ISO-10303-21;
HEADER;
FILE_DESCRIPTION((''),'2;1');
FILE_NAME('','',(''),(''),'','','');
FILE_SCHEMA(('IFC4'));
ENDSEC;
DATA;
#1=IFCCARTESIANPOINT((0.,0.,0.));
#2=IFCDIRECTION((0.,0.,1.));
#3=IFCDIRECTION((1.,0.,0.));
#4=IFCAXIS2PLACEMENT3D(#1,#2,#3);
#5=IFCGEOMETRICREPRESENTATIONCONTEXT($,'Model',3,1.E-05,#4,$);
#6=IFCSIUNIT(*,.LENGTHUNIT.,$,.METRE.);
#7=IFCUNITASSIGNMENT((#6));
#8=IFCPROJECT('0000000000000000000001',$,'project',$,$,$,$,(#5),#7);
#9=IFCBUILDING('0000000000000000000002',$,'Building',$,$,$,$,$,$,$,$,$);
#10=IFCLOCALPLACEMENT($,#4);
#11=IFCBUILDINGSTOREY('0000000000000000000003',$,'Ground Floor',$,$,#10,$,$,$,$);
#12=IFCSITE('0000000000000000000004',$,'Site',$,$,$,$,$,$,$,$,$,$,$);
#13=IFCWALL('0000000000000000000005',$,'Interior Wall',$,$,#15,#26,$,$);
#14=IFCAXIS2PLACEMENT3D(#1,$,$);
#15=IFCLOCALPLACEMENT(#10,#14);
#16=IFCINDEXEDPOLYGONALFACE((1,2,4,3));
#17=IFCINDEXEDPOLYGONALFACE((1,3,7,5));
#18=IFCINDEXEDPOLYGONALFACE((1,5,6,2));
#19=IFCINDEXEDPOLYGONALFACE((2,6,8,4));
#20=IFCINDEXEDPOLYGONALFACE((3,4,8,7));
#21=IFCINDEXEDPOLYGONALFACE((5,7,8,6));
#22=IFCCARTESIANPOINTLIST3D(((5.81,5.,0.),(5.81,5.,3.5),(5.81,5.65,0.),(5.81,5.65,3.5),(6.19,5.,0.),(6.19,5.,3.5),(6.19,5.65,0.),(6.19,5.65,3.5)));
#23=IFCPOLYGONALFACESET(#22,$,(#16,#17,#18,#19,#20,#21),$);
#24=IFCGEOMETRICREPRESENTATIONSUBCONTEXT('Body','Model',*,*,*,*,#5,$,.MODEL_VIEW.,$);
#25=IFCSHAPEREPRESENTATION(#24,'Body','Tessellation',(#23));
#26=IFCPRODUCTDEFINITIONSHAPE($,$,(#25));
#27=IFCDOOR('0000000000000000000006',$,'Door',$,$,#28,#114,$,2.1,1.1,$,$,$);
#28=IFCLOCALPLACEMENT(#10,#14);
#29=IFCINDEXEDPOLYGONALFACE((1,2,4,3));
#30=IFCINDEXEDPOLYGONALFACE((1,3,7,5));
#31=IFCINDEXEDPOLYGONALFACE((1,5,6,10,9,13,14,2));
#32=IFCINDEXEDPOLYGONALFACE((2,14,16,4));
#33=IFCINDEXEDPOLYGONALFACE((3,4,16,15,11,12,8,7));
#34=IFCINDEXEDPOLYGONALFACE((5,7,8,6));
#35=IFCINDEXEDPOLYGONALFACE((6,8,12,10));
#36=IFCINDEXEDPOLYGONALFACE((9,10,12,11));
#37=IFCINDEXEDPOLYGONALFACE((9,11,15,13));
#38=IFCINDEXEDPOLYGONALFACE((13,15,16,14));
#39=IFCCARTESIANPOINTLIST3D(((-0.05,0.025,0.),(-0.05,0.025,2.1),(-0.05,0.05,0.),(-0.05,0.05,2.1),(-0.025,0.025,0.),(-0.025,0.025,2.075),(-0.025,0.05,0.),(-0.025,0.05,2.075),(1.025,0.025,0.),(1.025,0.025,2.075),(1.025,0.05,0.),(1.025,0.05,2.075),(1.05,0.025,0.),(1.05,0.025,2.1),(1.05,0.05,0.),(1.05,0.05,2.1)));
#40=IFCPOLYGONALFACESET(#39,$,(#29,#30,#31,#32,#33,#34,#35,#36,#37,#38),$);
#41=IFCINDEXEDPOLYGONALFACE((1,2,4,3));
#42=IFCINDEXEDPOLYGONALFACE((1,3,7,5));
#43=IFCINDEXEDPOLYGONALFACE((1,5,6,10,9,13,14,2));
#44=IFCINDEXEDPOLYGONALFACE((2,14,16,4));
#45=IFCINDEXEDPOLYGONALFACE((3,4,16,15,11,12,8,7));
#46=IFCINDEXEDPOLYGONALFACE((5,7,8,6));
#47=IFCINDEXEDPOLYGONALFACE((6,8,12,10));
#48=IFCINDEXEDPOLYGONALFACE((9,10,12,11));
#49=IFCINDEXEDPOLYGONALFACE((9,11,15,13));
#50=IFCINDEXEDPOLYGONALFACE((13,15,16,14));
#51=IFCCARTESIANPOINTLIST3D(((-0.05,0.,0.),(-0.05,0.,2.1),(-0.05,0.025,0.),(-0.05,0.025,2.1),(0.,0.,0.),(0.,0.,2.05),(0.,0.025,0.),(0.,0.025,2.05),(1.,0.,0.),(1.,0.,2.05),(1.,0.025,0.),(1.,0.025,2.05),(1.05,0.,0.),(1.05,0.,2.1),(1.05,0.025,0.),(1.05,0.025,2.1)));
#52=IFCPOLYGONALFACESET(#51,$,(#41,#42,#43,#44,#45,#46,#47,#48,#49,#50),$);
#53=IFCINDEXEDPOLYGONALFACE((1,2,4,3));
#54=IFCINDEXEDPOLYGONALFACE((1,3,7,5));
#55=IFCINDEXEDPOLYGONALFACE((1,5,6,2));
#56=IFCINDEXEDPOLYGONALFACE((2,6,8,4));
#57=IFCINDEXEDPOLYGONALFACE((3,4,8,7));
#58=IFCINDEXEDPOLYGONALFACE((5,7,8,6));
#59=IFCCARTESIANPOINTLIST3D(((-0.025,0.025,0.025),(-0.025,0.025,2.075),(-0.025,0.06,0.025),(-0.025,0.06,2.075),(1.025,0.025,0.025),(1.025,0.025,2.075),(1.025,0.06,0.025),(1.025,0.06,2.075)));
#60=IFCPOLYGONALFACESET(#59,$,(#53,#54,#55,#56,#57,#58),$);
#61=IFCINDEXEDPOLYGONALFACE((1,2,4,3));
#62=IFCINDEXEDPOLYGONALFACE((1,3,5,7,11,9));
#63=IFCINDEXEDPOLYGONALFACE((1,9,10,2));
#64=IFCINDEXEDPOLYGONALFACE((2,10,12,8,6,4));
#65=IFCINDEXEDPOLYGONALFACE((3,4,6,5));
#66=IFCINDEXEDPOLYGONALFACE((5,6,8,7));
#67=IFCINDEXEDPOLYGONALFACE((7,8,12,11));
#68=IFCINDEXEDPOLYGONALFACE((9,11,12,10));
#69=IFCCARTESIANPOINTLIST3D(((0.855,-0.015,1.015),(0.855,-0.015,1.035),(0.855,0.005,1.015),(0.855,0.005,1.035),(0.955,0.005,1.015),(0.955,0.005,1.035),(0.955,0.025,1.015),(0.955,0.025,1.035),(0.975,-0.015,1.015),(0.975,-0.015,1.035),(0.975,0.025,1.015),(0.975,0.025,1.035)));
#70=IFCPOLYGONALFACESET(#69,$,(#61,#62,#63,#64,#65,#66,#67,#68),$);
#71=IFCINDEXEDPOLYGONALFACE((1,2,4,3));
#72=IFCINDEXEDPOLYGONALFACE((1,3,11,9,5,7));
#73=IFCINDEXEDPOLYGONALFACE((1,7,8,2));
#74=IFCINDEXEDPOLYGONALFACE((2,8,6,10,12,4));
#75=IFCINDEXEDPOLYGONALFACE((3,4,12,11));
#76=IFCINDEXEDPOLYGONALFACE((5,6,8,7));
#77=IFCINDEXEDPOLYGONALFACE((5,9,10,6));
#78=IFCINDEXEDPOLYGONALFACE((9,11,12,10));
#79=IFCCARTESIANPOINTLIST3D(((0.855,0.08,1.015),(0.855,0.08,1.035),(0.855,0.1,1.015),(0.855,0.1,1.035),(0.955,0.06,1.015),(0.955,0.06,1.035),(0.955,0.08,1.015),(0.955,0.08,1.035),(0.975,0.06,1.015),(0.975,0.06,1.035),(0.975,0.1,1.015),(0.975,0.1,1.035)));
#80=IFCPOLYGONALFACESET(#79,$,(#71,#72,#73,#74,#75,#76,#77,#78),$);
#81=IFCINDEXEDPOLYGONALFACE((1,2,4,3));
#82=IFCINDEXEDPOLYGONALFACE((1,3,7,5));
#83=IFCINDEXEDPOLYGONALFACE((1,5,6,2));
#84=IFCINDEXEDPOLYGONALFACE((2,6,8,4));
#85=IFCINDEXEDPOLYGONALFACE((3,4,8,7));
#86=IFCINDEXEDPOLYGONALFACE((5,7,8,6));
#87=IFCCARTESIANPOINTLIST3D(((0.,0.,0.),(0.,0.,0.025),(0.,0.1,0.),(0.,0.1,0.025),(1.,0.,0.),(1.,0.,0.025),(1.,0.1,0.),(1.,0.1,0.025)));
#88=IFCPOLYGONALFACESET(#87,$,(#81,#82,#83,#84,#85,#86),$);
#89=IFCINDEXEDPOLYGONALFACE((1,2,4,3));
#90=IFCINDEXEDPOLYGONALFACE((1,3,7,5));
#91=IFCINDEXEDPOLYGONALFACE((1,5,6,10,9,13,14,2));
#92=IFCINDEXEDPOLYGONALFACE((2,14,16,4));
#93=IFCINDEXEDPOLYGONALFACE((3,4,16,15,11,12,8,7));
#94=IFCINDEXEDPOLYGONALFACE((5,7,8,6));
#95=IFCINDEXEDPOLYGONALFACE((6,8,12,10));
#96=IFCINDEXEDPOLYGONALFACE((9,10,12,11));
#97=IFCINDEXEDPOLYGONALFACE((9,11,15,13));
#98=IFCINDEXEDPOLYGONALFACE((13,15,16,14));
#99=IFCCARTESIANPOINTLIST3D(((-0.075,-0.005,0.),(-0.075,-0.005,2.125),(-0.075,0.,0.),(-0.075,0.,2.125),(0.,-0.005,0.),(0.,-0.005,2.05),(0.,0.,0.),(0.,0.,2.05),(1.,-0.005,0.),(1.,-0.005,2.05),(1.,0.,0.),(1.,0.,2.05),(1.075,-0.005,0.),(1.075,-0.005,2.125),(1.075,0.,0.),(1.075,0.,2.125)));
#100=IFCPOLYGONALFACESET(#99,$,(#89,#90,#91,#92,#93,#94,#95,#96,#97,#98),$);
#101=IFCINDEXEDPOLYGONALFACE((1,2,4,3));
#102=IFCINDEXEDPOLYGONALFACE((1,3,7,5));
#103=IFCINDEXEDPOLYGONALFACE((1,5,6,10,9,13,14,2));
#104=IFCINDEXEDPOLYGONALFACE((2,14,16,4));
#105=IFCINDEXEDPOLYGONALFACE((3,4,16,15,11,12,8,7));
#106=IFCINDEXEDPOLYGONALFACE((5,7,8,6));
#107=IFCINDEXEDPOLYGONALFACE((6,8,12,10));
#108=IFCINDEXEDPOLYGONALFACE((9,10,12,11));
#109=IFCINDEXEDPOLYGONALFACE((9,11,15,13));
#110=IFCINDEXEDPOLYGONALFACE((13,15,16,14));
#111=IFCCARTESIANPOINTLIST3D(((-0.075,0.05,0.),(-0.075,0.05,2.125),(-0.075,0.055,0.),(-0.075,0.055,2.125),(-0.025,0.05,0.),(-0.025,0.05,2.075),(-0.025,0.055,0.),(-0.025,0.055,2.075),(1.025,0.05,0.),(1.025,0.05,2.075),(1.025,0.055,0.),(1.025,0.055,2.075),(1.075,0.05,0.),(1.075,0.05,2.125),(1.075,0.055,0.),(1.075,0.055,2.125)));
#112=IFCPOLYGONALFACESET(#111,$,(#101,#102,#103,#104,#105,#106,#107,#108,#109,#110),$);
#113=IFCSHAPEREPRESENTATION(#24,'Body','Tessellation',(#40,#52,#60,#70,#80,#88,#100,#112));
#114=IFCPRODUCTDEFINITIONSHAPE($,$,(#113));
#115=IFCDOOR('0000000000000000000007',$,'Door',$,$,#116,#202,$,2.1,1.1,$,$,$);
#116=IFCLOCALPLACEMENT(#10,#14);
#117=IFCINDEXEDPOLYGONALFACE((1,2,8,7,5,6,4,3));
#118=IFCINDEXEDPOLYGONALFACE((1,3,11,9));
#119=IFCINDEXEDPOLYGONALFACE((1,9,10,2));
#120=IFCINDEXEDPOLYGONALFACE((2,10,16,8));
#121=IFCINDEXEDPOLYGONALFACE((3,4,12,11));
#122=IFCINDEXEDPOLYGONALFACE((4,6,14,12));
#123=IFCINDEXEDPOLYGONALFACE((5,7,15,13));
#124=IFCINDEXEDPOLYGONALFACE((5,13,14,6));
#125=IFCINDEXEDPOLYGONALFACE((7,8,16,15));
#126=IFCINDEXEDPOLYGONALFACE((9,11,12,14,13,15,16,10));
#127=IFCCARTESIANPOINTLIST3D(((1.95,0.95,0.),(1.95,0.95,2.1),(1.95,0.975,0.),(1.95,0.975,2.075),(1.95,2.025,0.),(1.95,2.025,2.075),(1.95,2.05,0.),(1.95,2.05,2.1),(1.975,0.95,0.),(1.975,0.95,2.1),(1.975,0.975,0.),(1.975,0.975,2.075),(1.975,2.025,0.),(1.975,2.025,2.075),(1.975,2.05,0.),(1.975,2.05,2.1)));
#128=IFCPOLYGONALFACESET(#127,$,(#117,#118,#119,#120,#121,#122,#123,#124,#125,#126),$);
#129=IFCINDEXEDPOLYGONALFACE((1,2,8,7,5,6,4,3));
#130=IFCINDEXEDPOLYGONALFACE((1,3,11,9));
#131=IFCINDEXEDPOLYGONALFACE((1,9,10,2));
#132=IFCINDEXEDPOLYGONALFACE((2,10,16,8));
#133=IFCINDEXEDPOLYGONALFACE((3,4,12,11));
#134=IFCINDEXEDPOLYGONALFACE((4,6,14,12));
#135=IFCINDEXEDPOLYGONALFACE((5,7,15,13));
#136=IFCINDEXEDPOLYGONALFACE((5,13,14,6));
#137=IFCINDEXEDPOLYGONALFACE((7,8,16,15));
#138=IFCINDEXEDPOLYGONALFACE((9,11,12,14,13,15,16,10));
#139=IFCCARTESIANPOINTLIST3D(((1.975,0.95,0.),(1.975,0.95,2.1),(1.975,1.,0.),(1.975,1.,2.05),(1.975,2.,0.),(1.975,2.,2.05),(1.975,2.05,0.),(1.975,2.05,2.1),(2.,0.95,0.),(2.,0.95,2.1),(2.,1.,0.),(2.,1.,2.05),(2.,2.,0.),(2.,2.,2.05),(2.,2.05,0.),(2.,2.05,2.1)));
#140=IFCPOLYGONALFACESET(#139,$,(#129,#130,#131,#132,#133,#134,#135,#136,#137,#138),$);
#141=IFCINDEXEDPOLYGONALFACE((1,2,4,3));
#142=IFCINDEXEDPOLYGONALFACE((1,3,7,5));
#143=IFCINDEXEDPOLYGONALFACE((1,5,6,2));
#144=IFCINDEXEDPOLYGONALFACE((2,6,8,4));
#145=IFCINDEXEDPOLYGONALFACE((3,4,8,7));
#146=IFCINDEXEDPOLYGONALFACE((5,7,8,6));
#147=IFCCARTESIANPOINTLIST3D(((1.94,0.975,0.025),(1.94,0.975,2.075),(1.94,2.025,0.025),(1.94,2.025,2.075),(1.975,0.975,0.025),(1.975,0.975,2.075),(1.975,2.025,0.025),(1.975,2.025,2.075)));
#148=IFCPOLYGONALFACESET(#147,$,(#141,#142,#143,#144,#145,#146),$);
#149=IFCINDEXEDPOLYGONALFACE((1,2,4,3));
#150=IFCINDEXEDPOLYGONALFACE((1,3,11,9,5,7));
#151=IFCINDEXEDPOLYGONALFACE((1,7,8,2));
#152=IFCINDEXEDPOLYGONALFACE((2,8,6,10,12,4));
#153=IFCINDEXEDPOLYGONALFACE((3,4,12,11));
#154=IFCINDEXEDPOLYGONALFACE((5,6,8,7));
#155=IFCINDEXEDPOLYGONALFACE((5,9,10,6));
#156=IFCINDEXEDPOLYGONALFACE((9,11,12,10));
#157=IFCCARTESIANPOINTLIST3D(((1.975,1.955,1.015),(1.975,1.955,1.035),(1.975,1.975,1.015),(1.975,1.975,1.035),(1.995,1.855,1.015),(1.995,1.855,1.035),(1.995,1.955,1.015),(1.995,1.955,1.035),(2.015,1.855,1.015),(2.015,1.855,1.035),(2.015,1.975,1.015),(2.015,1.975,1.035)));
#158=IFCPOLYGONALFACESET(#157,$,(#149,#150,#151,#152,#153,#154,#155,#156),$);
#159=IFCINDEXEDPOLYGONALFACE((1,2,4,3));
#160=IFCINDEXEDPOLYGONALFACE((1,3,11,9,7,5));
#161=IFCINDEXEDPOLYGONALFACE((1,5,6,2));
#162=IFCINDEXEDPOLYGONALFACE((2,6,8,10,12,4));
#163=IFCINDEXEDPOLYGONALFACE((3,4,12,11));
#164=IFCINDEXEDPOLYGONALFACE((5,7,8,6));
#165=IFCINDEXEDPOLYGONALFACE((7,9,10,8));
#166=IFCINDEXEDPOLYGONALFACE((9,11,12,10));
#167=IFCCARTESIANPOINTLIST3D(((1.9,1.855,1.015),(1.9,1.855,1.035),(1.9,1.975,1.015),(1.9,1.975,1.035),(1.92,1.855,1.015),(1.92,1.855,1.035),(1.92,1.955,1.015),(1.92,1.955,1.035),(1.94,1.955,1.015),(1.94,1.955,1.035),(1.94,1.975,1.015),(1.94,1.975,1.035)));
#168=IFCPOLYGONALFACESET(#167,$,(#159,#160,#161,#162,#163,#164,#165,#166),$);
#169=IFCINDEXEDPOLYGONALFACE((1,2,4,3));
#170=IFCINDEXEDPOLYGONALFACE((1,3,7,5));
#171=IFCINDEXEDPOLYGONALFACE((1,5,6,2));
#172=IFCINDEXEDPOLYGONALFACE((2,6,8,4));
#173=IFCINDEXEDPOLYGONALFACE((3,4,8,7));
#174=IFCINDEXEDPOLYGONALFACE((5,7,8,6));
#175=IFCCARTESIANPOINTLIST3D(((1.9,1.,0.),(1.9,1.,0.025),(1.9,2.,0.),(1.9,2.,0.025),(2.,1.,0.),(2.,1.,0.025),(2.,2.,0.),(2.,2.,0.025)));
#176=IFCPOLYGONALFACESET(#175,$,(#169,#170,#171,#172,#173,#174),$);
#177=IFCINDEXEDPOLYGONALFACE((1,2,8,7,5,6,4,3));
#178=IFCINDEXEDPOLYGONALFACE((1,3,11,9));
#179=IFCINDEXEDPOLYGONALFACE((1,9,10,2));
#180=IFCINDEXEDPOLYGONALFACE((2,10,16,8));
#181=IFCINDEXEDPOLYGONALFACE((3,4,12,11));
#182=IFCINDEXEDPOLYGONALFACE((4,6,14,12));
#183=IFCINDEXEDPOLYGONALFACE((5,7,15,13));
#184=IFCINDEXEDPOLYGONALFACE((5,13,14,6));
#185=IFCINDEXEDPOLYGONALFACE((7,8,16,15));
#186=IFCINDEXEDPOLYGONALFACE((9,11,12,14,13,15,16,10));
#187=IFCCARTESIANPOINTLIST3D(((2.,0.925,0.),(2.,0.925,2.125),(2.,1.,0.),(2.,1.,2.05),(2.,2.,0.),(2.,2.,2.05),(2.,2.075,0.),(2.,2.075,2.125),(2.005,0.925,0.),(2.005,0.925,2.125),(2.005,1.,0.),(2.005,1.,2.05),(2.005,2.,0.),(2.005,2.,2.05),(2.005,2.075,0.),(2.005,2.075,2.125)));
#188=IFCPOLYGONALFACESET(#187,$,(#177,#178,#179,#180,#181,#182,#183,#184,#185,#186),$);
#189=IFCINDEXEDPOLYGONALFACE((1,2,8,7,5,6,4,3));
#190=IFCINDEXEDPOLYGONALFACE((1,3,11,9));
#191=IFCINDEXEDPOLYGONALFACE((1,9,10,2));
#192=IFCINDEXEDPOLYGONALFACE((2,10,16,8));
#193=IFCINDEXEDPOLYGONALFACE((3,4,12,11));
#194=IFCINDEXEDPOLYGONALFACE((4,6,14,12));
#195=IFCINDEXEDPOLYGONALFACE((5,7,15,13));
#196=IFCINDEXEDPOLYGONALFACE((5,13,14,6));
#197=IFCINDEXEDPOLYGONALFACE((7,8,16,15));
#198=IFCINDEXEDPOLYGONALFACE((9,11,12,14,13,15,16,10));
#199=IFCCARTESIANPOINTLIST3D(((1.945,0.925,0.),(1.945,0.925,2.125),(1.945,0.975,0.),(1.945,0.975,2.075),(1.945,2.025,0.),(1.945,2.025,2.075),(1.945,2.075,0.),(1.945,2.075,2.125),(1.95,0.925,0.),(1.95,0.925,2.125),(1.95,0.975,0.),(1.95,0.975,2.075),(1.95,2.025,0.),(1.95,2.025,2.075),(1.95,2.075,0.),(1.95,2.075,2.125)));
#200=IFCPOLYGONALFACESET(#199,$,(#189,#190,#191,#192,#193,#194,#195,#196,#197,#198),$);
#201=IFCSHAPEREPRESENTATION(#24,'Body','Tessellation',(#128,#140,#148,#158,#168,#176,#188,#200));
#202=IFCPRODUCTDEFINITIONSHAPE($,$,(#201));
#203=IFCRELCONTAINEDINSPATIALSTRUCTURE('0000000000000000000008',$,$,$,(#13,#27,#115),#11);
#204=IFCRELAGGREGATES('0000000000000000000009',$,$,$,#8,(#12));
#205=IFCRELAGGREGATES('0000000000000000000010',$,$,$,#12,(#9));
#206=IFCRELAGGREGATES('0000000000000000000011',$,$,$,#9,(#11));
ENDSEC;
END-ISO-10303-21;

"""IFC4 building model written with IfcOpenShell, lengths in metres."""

from ifc_helpers import new_model, si_unit, frame, origin_with_axes, place, context, subcontext, project, spatial, line, indexed_curve, outline, extrude, element, save


model = new_model("IFC4")

# Units and contexts
model_context = context("Model", 3, precision=1e-05, world=origin_with_axes())
body_context = subcontext(model_context, "Body", "Model", "MODEL_VIEW")
ifc_project = project(units=[si_unit("LENGTHUNIT", "METRE")], contexts=[model_context])

# Site, building, storey
site = spatial("IfcSite", under=ifc_project, Name="Site")
building = spatial("IfcBuilding", under=site, Name="Building")
storey_placement = place(None, origin_with_axes())
storey = spatial("IfcBuildingStorey", under=building, at=storey_placement, Name="Ground Floor")

# Wall
wall_1_placement = place(storey_placement, frame((6.0, 5.0, 0.0), z_axis=(0.0, 0.0, 1.0), x_axis=(0.0, 1.0, 0.0)))
element("IfcWall", 1, at=wall_1_placement, inside=storey, Name="Interior Wall", context=body_context, shape_type="SweptSolid", body=[
    extrude(outline(indexed_curve([(0.0, 0.0), (0.0, 0.38), (0.65, 0.38), (0.65, 0.0), (0.0, 0.0)], self_intersect=False)), frame((0.0, -0.19, 0.0), z_axis=(0.0, 0.0, 1.0), x_axis=(1.0, 0.0, 0.0)), (0.0, 0.0, 1.0), 3.5),
])

# Doors
door_1_placement = place(storey_placement, frame((-0.05, 0.0, 0.0), z_axis=(0.0, 0.0, 1.0), x_axis=(1.0, 0.0, 0.0)))
element("IfcDoor", 2, at=door_1_placement, inside=storey, Name="Door", OverallHeight=2.1, OverallWidth=1.1, context=body_context, shape_type="SweptSolid", body=[
    extrude(outline(indexed_curve([(0.0, 0.0), (0.0, 2.1), (1.1, 2.1), (1.1, 0.0), (1.075, 0.0), (1.075, 2.075), (0.025, 2.075), (0.025, 0.0)], segments=[line(1, 2, 3, 4, 5, 6, 7, 8, 1)])), frame((0.0, 0.025, 0.0), z_axis=(0.0, -1.0, 0.0), x_axis=(1.0, 0.0, 0.0)), (0.0, 0.0, -1.0), 0.025),
    extrude(outline(indexed_curve([(0.0, 0.0), (0.0, 2.1), (1.1, 2.1), (1.1, 0.0), (1.05, 0.0), (1.05, 2.05), (0.05, 2.05), (0.05, 0.0)], segments=[line(1, 2, 3, 4, 5, 6, 7, 8, 1)])), frame((0.0, 0.0, 0.0), z_axis=(0.0, -1.0, 0.0), x_axis=(1.0, 0.0, 0.0)), (0.0, 0.0, -1.0), 0.025),
    extrude(outline(indexed_curve([(0.0, 0.0), (1.05, 0.0), (1.05, 0.035), (0.0, 0.035)], segments=[line(1, 2, 3, 4, 1)])), frame((0.025, 0.025, 0.025), z_axis=(0.0, 0.0, 1.0), x_axis=(1.0, 0.0, 0.0)), (0.0, 0.0, 1.0), 2.05),
    extrude(outline(indexed_curve([(0.0, 0.0), (0.0, -0.04), (-0.12, -0.04), (-0.12, -0.02), (-0.02, -0.02), (-0.02, 0.0)], segments=[line(1, 2, 3, 4, 5, 6, 1)])), frame((1.025, 0.025, 1.015), z_axis=(0.0, 0.0, 1.0), x_axis=(1.0, 0.0, 0.0)), (0.0, 0.0, 1.0), 0.02),
    extrude(outline(indexed_curve([(0.0, 0.0), (0.0, 0.04), (-0.12, 0.04), (-0.12, 0.02), (-0.02, 0.02), (-0.02, 0.0)], segments=[line(1, 2, 3, 4, 5, 6, 1)])), frame((1.025, 0.06, 1.015), z_axis=(0.0, 0.0, 1.0), x_axis=(1.0, 0.0, 0.0)), (0.0, 0.0, 1.0), 0.02),
    extrude(outline(indexed_curve([(0.0, 0.0), (1.0, 0.0), (1.0, 0.1), (0.0, 0.1)], segments=[line(1, 2, 3, 4, 1)])), frame((0.05, 0.0, 0.0), z_axis=(0.0, 0.0, 1.0), x_axis=(1.0, 0.0, 0.0)), (0.0, 0.0, 1.0), 0.025),
    extrude(outline(indexed_curve([(0.0, 0.0), (0.0, 2.125), (1.15, 2.125), (1.15, 0.0), (1.075, 0.0), (1.075, 2.05), (0.075, 2.05), (0.075, 0.0)], segments=[line(1, 2, 3, 4, 5, 6, 7, 8, 1)])), frame((-0.025, -0.005, 0.0), z_axis=(0.0, -1.0, 0.0), x_axis=(1.0, 0.0, 0.0)), (0.0, 0.0, -1.0), 0.005),
    extrude(outline(indexed_curve([(0.0, 0.0), (0.0, 2.125), (1.15, 2.125), (1.15, 0.0), (1.1, 0.0), (1.1, 2.075), (0.05, 2.075), (0.05, 0.0)], segments=[line(1, 2, 3, 4, 5, 6, 7, 8, 1)])), frame((-0.025, 0.05, 0.0), z_axis=(0.0, -1.0, 0.0), x_axis=(1.0, 0.0, 0.0)), (0.0, 0.0, -1.0), 0.005),
])
door_2_placement = place(storey_placement, frame((2.0, 0.95, 0.0), z_axis=(0.0, 0.0, 1.0), x_axis=(0.0, 1.0, 0.0)))
element("IfcDoor", 3, at=door_2_placement, inside=storey, Name="Door", OverallHeight=2.1, OverallWidth=1.1, context=body_context, shape_type="SweptSolid", body=[
    extrude(outline(indexed_curve([(0.0, 0.0), (0.0, 2.1), (1.1, 2.1), (1.1, 0.0), (1.075, 0.0), (1.075, 2.075), (0.025, 2.075), (0.025, 0.0)], segments=[line(1, 2, 3, 4, 5, 6, 7, 8, 1)])), frame((0.0, 0.025, 0.0), z_axis=(0.0, -1.0, 0.0), x_axis=(1.0, 0.0, 0.0)), (0.0, 0.0, -1.0), 0.025),
    extrude(outline(indexed_curve([(0.0, 0.0), (0.0, 2.1), (1.1, 2.1), (1.1, 0.0), (1.05, 0.0), (1.05, 2.05), (0.05, 2.05), (0.05, 0.0)], segments=[line(1, 2, 3, 4, 5, 6, 7, 8, 1)])), frame((0.0, 0.0, 0.0), z_axis=(0.0, -1.0, 0.0), x_axis=(1.0, 0.0, 0.0)), (0.0, 0.0, -1.0), 0.025),
    extrude(outline(indexed_curve([(0.0, 0.0), (1.05, 0.0), (1.05, 0.035), (0.0, 0.035)], segments=[line(1, 2, 3, 4, 1)])), frame((0.025, 0.025, 0.025), z_axis=(0.0, 0.0, 1.0), x_axis=(1.0, 0.0, 0.0)), (0.0, 0.0, 1.0), 2.05),
    extrude(outline(indexed_curve([(0.0, 0.0), (0.0, -0.04), (-0.12, -0.04), (-0.12, -0.02), (-0.02, -0.02), (-0.02, 0.0)], segments=[line(1, 2, 3, 4, 5, 6, 1)])), frame((1.025, 0.025, 1.015), z_axis=(0.0, 0.0, 1.0), x_axis=(1.0, 0.0, 0.0)), (0.0, 0.0, 1.0), 0.02),
    extrude(outline(indexed_curve([(0.0, 0.0), (0.0, 0.04), (-0.12, 0.04), (-0.12, 0.02), (-0.02, 0.02), (-0.02, 0.0)], segments=[line(1, 2, 3, 4, 5, 6, 1)])), frame((1.025, 0.06, 1.015), z_axis=(0.0, 0.0, 1.0), x_axis=(1.0, 0.0, 0.0)), (0.0, 0.0, 1.0), 0.02),
    extrude(outline(indexed_curve([(0.0, 0.0), (1.0, 0.0), (1.0, 0.1), (0.0, 0.1)], segments=[line(1, 2, 3, 4, 1)])), frame((0.05, 0.0, 0.0), z_axis=(0.0, 0.0, 1.0), x_axis=(1.0, 0.0, 0.0)), (0.0, 0.0, 1.0), 0.025),
    extrude(outline(indexed_curve([(0.0, 0.0), (0.0, 2.125), (1.15, 2.125), (1.15, 0.0), (1.075, 0.0), (1.075, 2.05), (0.075, 2.05), (0.075, 0.0)], segments=[line(1, 2, 3, 4, 5, 6, 7, 8, 1)])), frame((-0.025, -0.005, 0.0), z_axis=(0.0, -1.0, 0.0), x_axis=(1.0, 0.0, 0.0)), (0.0, 0.0, -1.0), 0.005),
    extrude(outline(indexed_curve([(0.0, 0.0), (0.0, 2.125), (1.15, 2.125), (1.15, 0.0), (1.1, 0.0), (1.1, 2.075), (0.05, 2.075), (0.05, 0.0)], segments=[line(1, 2, 3, 4, 5, 6, 7, 8, 1)])), frame((-0.025, 0.05, 0.0), z_axis=(0.0, -1.0, 0.0), x_axis=(1.0, 0.0, 0.0)), (0.0, 0.0, -1.0), 0.005),
])

save(model, "model.ifc")
